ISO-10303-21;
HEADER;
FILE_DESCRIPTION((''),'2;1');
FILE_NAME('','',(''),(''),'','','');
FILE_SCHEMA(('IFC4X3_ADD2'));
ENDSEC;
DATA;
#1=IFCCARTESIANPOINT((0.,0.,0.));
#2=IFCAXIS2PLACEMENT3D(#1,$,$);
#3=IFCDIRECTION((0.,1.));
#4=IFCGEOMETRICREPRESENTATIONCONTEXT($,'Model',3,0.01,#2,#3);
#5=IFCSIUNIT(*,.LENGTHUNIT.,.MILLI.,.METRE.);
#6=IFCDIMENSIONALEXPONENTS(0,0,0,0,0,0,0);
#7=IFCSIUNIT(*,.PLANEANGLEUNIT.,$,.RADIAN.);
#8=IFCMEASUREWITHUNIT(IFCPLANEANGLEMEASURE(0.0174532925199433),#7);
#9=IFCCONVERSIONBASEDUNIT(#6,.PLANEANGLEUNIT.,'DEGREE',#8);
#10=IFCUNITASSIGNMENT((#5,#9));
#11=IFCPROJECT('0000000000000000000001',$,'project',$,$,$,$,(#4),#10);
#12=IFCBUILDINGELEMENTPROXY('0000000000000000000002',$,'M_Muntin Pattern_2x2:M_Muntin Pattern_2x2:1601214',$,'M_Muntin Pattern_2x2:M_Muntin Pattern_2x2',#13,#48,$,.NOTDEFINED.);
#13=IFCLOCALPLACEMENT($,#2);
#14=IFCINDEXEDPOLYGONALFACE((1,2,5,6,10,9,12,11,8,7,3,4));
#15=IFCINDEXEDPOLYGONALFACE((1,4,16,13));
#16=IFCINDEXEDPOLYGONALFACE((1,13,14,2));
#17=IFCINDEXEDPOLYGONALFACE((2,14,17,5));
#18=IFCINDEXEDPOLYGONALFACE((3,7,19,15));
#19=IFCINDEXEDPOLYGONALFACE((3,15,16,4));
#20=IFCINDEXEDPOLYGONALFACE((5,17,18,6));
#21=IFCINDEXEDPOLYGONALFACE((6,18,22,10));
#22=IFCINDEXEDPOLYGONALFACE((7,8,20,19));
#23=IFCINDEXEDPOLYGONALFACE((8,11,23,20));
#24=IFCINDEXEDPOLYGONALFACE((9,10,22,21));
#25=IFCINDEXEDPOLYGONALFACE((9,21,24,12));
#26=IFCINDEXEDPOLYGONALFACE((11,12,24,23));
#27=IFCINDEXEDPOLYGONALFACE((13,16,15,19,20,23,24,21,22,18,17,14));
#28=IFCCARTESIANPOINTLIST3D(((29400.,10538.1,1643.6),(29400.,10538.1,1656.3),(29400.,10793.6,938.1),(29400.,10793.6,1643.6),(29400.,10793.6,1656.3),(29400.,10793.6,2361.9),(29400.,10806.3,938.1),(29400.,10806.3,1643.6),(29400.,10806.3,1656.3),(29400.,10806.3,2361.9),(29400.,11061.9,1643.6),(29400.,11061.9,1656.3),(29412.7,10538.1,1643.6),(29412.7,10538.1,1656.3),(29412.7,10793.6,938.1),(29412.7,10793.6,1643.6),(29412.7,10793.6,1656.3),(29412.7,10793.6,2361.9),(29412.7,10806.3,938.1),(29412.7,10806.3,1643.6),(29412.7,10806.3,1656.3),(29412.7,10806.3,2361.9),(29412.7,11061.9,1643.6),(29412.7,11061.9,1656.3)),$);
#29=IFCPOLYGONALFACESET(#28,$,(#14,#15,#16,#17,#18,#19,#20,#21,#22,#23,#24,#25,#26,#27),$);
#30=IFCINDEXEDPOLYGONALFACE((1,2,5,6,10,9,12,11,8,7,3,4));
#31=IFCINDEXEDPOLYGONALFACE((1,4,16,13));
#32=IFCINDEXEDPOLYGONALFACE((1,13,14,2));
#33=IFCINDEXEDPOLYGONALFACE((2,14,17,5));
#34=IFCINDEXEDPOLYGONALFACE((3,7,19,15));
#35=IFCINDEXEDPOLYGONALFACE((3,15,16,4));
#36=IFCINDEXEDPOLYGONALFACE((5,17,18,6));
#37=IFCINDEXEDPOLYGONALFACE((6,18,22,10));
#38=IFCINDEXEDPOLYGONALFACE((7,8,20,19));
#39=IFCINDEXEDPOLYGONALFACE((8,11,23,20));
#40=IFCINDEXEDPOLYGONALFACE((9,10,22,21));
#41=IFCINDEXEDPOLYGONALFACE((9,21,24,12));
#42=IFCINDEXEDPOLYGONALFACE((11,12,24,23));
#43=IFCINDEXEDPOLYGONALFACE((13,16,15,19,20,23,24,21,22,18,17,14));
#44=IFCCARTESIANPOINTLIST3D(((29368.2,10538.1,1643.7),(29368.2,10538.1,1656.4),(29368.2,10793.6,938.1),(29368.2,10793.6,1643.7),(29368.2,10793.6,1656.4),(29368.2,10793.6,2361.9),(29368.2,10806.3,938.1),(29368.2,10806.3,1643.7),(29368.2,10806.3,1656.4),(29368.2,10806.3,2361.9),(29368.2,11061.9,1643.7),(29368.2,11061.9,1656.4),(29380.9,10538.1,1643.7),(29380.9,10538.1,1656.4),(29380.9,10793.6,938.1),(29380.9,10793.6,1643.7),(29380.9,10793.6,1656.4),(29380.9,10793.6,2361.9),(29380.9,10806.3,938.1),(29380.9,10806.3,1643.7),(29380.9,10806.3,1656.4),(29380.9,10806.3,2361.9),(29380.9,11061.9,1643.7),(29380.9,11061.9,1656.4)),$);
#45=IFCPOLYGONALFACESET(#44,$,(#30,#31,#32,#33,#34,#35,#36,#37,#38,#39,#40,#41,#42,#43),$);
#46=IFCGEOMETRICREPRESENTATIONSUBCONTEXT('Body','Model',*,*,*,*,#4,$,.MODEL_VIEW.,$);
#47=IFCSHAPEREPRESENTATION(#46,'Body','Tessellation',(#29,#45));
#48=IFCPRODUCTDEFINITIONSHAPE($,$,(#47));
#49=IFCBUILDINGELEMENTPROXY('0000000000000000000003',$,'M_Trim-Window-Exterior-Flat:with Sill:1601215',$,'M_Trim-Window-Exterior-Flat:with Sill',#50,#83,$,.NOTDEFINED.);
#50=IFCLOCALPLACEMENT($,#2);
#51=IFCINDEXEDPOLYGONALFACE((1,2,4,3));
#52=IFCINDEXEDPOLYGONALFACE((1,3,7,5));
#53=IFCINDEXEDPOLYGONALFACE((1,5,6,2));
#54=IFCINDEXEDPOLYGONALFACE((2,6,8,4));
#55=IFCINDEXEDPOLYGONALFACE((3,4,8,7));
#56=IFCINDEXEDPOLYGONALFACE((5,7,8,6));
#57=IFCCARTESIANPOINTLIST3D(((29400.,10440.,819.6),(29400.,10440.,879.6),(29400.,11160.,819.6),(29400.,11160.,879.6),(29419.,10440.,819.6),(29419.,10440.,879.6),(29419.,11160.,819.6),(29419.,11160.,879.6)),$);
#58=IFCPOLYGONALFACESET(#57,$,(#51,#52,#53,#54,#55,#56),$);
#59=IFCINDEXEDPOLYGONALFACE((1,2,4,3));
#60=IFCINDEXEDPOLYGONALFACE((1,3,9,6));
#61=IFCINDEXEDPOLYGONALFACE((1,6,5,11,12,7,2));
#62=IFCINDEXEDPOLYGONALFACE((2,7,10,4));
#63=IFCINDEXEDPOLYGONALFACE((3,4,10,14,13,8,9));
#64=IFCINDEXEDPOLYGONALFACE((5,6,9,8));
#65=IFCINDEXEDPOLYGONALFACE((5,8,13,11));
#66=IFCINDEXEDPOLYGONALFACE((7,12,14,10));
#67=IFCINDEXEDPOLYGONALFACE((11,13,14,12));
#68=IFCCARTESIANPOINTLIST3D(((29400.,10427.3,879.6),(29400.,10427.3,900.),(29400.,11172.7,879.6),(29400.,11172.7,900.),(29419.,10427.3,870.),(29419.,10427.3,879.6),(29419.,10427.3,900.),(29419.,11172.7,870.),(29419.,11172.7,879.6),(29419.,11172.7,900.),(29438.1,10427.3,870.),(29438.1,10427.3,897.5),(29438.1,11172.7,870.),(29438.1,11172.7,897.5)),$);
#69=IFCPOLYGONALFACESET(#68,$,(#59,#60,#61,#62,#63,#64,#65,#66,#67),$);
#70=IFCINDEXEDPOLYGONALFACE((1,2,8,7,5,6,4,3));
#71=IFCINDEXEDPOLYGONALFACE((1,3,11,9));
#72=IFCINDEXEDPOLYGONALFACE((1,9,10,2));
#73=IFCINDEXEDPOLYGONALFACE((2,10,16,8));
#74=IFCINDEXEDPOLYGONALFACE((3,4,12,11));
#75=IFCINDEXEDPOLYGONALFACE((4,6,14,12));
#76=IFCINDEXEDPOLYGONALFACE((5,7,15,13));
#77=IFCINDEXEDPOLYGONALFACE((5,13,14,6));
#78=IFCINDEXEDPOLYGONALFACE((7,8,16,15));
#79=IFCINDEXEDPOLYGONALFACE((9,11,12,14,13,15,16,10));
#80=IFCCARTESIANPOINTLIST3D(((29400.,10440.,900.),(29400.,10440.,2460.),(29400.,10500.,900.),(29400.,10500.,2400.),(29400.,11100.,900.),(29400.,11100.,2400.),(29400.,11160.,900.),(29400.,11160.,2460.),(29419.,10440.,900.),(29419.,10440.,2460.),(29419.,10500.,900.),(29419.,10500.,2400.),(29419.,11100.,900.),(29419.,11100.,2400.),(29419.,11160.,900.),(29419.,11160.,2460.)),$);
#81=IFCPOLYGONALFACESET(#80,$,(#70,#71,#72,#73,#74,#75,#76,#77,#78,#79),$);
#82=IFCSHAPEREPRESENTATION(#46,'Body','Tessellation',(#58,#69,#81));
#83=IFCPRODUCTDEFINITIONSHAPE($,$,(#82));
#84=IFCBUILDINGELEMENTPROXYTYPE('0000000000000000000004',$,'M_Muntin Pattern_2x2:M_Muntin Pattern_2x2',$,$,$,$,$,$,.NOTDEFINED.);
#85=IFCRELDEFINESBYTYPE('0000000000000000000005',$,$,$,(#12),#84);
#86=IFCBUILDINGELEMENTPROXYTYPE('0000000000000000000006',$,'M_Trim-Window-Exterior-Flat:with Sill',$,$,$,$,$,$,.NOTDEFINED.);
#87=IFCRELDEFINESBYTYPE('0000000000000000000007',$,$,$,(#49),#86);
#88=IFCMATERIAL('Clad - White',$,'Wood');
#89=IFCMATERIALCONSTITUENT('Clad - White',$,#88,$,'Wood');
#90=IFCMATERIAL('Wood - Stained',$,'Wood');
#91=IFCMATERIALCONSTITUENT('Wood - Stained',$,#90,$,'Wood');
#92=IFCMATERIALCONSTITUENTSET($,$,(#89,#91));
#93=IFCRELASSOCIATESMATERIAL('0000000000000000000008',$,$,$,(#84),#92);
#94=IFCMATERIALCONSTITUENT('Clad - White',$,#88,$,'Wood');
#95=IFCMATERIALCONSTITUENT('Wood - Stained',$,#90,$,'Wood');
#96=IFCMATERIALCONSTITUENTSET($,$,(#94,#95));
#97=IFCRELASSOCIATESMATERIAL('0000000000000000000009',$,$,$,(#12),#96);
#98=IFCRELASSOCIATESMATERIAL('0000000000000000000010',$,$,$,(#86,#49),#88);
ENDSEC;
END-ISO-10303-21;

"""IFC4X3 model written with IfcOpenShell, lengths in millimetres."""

from ifc_helpers import new_model, entity, si_unit, converted_unit, direction, frame, frame_2d, origin, place, context, subcontext, project, polyline, rectangle, outline, extrude, source, transform, mapped, material, constituent, constituent_set, type_object, type_shapes, element, save


model = new_model("IFC4X3")

# Units and contexts
model_context = context("Model", 3, precision=0.01, world=origin(), true_north=direction((0.0, 1.0)))
body_context = subcontext(model_context, "Body", "Model", "MODEL_VIEW")
ifc_project = project(units=[si_unit("LENGTHUNIT", "METRE", prefix="MILLI"), converted_unit("PLANEANGLEUNIT", "DEGREE", entity("IfcPlaneAngleMeasure", 0.0174532925199433), si_unit("PLANEANGLEUNIT", "RADIAN"), dimensions=[0, 0, 0, 0, 0, 0, 0])], contexts=[model_context])

# Shared definitions
placement_1 = place(None, origin())
placement_2 = place(placement_1, origin())
placement_3 = place(placement_2, origin())

# Building element proxies
ifc_material_1 = material(Name="Clad - White", Category="Wood")
ifc_constituent_1 = constituent(ifc_material_1, Name="Clad - White", Category="Wood")
ifc_material_2 = material(Name="Wood - Stained", Category="Wood")
ifc_constituent_2 = constituent(ifc_material_2, Name="Wood - Stained", Category="Wood")
ifc_constituent_set_1 = constituent_set(constituents=[ifc_constituent_1, ifc_constituent_2])
ifc_constituent_3 = constituent(ifc_material_1, Name="Clad - White", Category="Wood")
ifc_constituent_4 = constituent(ifc_material_2, Name="Wood - Stained", Category="Wood")
ifc_constituent_set_2 = constituent_set(constituents=[ifc_constituent_3, ifc_constituent_4])
building_element_proxy_type_1 = type_object("IfcBuildingElementProxyType", Name="M_Muntin Pattern_2x2:M_Muntin Pattern_2x2", PredefinedType="NOTDEFINED", material=ifc_constituent_set_2)
shared_shape_1 = source(origin(), body_context, "Body", "SweptSolid", [
    extrude(outline(polyline([(6.4, -6.4), (711.9, -6.4), (711.9, 6.3), (6.4, 6.3), (6.4, 261.9), (-6.3, 261.9), (-6.3, 6.3), (-711.9, 6.3), (-711.9, -6.4), (-6.3, -6.4), (-6.3, -261.9), (6.4, -261.9), (6.4, -6.4)])), frame((0.0, -22.2, 711.9), z_axis=(0.0, 1.0, 0.0), x_axis=(0.0, 0.0, 1.0)), (0.0, 0.0, 1.0), 12.7),
    extrude(outline(polyline([(6.4, -6.4), (711.9, -6.4), (711.9, 6.3), (6.4, 6.3), (6.4, 261.9), (-6.3, 261.9), (-6.3, 6.3), (-711.9, 6.3), (-711.9, -6.4), (-6.3, -6.4), (-6.3, -261.9), (6.4, -261.9), (6.4, -6.4)])), frame((0.0, 9.5, 711.9), z_axis=(0.0, 1.0, 0.0), x_axis=(0.0, 0.0, 1.0)), (0.0, 0.0, 1.0), 12.7),
])
type_shapes(building_element_proxy_type_1, [shared_shape_1])
proxy_1_placement = place(placement_3, frame((29390.5, 10800.0, 938.1), z_axis=(0.0, 0.0, 1.0), x_axis=(0.0, 1.0, 0.0)))
element("IfcBuildingElementProxy", 1, at=proxy_1_placement, type_object=building_element_proxy_type_1, material=ifc_constituent_set_1, Name="M_Muntin Pattern_2x2:M_Muntin Pattern_2x2:1601214", ObjectType="M_Muntin Pattern_2x2:M_Muntin Pattern_2x2", PredefinedType="NOTDEFINED", context=body_context, shape_type="MappedRepresentation", body=[
    mapped(shared_shape_1, transform((0.0, 0.0, 0.0), scale=1.0)),
])
building_element_proxy_type_2 = type_object("IfcBuildingElementProxyType", Name="M_Trim-Window-Exterior-Flat:with Sill", PredefinedType="NOTDEFINED", material=ifc_material_1)
shared_shape_2 = source(origin(), body_context, "Body", "SweptSolid", [
    extrude(rectangle(XDim=720.0, YDim=60.0, at=frame_2d((0.0, 0.0), x_axis=(1.0, 0.0))), frame((0.0, -1550.4, 0.0), z_axis=(0.0, 0.0, 1.0), x_axis=(-1.0, 0.0, 0.0)), (0.0, 0.0, 1.0), 19.1),
    extrude(outline(polyline([(-19.0, -15.2), (0.0, -15.2), (0.0, -5.7), (19.0, -5.7), (19.0, 14.8), (0.0, 14.8), (-19.0, 12.3), (-19.0, -15.2)])), frame((-372.7, -1514.8, 19.0), z_axis=(1.0, 0.0, 0.0), x_axis=(0.0, 0.0, -1.0)), (0.0, 0.0, 1.0), 745.4),
    extrude(outline(polyline([(-795.0, -360.0), (765.0, -360.0), (765.0, -300.0), (-735.0, -300.0), (-735.0, 300.0), (765.0, 300.0), (765.0, 360.0), (-795.0, 360.0), (-795.0, -360.0)])), frame((0.0, -735.0, 0.0), z_axis=(0.0, 0.0, 1.0), x_axis=(0.0, -1.0, 0.0)), (0.0, 0.0, 1.0), 19.1),
])
type_shapes(building_element_proxy_type_2, [shared_shape_2])
proxy_2_placement = place(placement_3, frame((29400.0, 10800.0, 2400.0), z_axis=(1.0, 0.0, 0.0), x_axis=(0.0, 1.0, 0.0)))
element("IfcBuildingElementProxy", 2, at=proxy_2_placement, type_object=building_element_proxy_type_2, material=ifc_material_1, Name="M_Trim-Window-Exterior-Flat:with Sill:1601215", ObjectType="M_Trim-Window-Exterior-Flat:with Sill", PredefinedType="NOTDEFINED", context=body_context, shape_type="MappedRepresentation", body=[
    mapped(shared_shape_2, transform((0.0, 0.0, 0.0), scale=1.0)),
])

save(model, "model.ifc")
